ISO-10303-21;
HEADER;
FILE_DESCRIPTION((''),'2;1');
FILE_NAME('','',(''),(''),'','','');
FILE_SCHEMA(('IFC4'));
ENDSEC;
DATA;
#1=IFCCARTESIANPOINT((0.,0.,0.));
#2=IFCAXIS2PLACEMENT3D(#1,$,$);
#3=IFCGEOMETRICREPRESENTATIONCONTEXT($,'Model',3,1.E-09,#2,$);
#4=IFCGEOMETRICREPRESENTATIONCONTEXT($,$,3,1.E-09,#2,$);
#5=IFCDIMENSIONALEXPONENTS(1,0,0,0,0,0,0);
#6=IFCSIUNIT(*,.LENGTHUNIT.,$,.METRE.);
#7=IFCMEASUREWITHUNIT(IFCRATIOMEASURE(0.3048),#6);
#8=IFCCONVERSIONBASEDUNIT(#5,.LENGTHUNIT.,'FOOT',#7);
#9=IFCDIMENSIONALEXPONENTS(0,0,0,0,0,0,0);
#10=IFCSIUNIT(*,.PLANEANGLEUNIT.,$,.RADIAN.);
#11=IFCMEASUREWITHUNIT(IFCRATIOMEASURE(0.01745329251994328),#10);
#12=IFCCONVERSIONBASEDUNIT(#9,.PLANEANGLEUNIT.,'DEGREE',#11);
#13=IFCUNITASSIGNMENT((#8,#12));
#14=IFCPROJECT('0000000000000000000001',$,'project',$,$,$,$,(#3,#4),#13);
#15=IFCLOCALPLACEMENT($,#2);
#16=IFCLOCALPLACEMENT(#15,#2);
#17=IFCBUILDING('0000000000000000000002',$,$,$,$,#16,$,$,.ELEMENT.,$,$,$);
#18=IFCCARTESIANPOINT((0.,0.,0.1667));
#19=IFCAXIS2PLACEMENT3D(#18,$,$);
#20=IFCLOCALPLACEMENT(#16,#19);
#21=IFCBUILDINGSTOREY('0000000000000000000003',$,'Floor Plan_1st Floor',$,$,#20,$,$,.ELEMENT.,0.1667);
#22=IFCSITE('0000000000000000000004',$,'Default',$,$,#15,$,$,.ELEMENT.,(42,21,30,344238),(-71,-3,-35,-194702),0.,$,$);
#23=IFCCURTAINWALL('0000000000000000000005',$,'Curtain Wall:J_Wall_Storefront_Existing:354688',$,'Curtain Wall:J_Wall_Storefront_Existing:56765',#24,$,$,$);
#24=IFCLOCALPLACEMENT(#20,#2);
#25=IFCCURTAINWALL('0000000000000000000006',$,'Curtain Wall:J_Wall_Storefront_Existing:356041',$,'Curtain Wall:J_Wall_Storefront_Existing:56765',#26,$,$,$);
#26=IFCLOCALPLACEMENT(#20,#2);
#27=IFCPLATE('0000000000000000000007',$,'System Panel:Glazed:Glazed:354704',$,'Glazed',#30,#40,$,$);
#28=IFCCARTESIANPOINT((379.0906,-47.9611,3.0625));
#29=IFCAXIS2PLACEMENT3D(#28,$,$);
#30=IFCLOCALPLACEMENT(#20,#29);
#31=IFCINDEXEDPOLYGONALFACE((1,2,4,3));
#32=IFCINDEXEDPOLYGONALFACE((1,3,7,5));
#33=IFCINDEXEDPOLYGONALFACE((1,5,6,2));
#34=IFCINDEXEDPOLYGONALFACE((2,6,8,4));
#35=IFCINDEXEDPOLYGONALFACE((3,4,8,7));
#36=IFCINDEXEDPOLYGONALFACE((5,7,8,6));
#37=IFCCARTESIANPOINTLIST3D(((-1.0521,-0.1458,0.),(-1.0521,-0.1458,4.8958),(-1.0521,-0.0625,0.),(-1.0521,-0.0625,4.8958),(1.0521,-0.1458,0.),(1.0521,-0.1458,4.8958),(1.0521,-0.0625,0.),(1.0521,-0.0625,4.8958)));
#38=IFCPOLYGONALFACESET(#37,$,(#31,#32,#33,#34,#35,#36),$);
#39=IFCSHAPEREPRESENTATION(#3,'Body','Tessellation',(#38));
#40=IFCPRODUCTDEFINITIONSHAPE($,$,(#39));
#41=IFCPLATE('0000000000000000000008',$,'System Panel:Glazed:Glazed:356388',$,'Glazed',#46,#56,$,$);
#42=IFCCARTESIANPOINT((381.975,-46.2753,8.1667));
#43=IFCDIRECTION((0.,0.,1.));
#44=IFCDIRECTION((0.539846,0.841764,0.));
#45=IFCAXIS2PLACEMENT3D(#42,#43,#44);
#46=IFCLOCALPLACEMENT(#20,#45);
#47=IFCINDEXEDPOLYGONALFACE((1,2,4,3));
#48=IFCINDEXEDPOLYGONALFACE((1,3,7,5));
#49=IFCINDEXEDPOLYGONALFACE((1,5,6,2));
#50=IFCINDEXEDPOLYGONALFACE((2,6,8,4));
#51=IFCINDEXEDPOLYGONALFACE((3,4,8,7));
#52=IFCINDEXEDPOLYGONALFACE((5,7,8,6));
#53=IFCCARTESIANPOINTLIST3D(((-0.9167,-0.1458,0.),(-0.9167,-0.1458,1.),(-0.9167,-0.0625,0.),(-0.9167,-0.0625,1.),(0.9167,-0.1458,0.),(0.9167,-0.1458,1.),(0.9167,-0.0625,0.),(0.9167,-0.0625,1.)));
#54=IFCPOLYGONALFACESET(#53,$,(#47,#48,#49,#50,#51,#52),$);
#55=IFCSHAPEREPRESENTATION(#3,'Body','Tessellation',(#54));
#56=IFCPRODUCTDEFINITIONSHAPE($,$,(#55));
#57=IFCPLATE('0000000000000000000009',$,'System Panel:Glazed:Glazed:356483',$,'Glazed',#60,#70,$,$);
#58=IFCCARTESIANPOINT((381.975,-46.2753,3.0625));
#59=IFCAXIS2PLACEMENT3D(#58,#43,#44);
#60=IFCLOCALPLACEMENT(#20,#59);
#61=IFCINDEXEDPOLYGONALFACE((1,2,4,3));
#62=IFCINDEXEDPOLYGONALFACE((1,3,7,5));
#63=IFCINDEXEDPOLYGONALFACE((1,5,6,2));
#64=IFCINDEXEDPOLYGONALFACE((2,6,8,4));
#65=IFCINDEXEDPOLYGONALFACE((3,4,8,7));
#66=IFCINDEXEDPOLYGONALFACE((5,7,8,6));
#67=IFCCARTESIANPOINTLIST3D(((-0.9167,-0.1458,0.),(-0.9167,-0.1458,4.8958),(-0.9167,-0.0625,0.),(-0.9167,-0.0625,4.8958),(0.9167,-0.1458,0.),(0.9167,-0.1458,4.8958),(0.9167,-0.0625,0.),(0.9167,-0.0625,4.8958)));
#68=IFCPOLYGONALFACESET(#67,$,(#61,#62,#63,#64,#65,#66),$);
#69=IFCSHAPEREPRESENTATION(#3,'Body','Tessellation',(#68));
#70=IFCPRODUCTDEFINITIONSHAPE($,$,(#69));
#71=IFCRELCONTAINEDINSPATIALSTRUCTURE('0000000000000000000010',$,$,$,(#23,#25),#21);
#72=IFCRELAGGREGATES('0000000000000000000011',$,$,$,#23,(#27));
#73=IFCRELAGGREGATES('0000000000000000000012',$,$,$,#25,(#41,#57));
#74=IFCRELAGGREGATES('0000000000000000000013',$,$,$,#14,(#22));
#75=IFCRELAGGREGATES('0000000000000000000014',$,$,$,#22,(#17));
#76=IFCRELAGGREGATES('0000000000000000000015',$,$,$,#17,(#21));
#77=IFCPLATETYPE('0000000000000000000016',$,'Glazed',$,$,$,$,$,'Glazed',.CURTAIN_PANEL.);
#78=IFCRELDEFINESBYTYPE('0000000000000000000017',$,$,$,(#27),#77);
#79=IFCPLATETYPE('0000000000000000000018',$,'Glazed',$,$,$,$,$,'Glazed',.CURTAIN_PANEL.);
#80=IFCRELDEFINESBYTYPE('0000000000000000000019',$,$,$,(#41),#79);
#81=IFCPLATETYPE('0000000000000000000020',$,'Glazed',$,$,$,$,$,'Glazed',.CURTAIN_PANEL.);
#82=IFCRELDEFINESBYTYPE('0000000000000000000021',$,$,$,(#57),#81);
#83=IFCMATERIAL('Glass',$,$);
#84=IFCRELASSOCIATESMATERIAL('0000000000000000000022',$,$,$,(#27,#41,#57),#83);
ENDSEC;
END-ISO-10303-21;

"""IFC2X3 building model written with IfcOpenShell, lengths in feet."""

from ifc_helpers import new_model, entity, si_unit, converted_unit, frame, origin, origin_2d_with_axis, place, context, project, spatial, rectangle, extrude, source, transform, mapped, material, type_object, type_shapes, element, aggregate, save


model = new_model("IFC2X3")

# Units and contexts
model_context = context("Model", 3, precision=1e-09, world=origin())
context_of_model = context(None, 3, precision=1e-09, world=origin())
ifc_project = project(units=[converted_unit("LENGTHUNIT", "FOOT", entity("IfcRatioMeasure", 0.3048), si_unit("LENGTHUNIT", "METRE"), dimensions=[1, 0, 0, 0, 0, 0, 0]), converted_unit("PLANEANGLEUNIT", "DEGREE", entity("IfcRatioMeasure", 0.01745329251994328), si_unit("PLANEANGLEUNIT", "RADIAN"), dimensions=[0, 0, 0, 0, 0, 0, 0])], contexts=[model_context, context_of_model])

# Site, building, storey
site_placement = place(None, origin())
site = spatial("IfcSite", under=ifc_project, at=site_placement, Name="Default", CompositionType="ELEMENT", RefLatitude=(42, 21, 30, 344238), RefLongitude=(-71, -3, -35, -194702), RefElevation=0.0)
building_placement = place(site_placement, origin())
building = spatial("IfcBuilding", under=site, at=building_placement, CompositionType="ELEMENT")
storey_placement = place(building_placement, frame((0.0, 0.0, 0.1667)))
storey = spatial("IfcBuildingStorey", under=building, at=storey_placement, Name="Floor Plan_1st Floor", CompositionType="ELEMENT", Elevation=0.1667)

# Curtain walls
curtain_wall_1_placement = place(storey_placement, origin())
curtain_wall_1 = element("IfcCurtainWall", 1, at=curtain_wall_1_placement, inside=storey, Name="Curtain Wall:J_Wall_Storefront_Existing:354688", ObjectType="Curtain Wall:J_Wall_Storefront_Existing:56765")
curtain_wall_2_placement = place(storey_placement, origin())
curtain_wall_2 = element("IfcCurtainWall", 2, at=curtain_wall_2_placement, inside=storey, Name="Curtain Wall:J_Wall_Storefront_Existing:356041", ObjectType="Curtain Wall:J_Wall_Storefront_Existing:56765")

# Plates
ifc_material_1 = material(Name="Glass")
plate_type_1 = type_object("IfcPlateType", Name="Glazed", ElementType="Glazed", PredefinedType="CURTAIN_PANEL")
shared_shape_1 = source(origin(), model_context, "Body", "SweptSolid", [
    extrude(rectangle(XDim=0.0833, YDim=2.1042, at=origin_2d_with_axis()), frame((0.0, -0.1042, 0.0), z_axis=(0.0, 0.0, 1.0), x_axis=(0.0, 1.0, 0.0)), (0.0, 0.0, 1.0), 4.8958),
])
type_shapes(plate_type_1, [shared_shape_1])
plate_1_placement = place(storey_placement, frame((379.0906, -47.9611, 3.0625)))
plate_1 = element("IfcPlate", 3, at=plate_1_placement, type_object=plate_type_1, material=ifc_material_1, Name="System Panel:Glazed:Glazed:354704", ObjectType="Glazed", context=model_context, shape_type="MappedRepresentation", body=[
    mapped(shared_shape_1, transform((0.0, 0.0, 0.0), scale=1.0)),
])
aggregate(curtain_wall_1, [plate_1])
plate_type_2 = type_object("IfcPlateType", Name="Glazed", ElementType="Glazed", PredefinedType="CURTAIN_PANEL")
shared_shape_2 = source(origin(), model_context, "Body", "SweptSolid", [
    extrude(rectangle(XDim=0.0833, YDim=1.8333, at=origin_2d_with_axis()), frame((0.0, -0.1042, 0.0), z_axis=(0.0, 0.0, 1.0), x_axis=(0.0, 1.0, 0.0)), (0.0, 0.0, 1.0), 1.0),
])
type_shapes(plate_type_2, [shared_shape_2])
plate_2_placement = place(storey_placement, frame((381.975, -46.2753, 8.1667), z_axis=(0.0, 0.0, 1.0), x_axis=(0.539846, 0.841764, 0.0)))
plate_2 = element("IfcPlate", 4, at=plate_2_placement, type_object=plate_type_2, material=ifc_material_1, Name="System Panel:Glazed:Glazed:356388", ObjectType="Glazed", context=model_context, shape_type="MappedRepresentation", body=[
    mapped(shared_shape_2, transform((0.0, 0.0, 0.0), scale=1.0)),
])
plate_type_3 = type_object("IfcPlateType", Name="Glazed", ElementType="Glazed", PredefinedType="CURTAIN_PANEL")
shared_shape_3 = source(origin(), model_context, "Body", "SweptSolid", [
    extrude(rectangle(XDim=0.0833, YDim=1.8333, at=origin_2d_with_axis()), frame((0.0, -0.1042, 0.0), z_axis=(0.0, 0.0, 1.0), x_axis=(0.0, 1.0, 0.0)), (0.0, 0.0, 1.0), 4.8958),
])
type_shapes(plate_type_3, [shared_shape_3])
plate_3_placement = place(storey_placement, frame((381.975, -46.2753, 3.0625), z_axis=(0.0, 0.0, 1.0), x_axis=(0.539846, 0.841764, 0.0)))
plate_3 = element("IfcPlate", 5, at=plate_3_placement, type_object=plate_type_3, material=ifc_material_1, Name="System Panel:Glazed:Glazed:356483", ObjectType="Glazed", context=model_context, shape_type="MappedRepresentation", body=[
    mapped(shared_shape_3, transform((0.0, 0.0, 0.0), scale=1.0)),
])
aggregate(curtain_wall_2, [plate_2, plate_3])

save(model, "model.ifc")
